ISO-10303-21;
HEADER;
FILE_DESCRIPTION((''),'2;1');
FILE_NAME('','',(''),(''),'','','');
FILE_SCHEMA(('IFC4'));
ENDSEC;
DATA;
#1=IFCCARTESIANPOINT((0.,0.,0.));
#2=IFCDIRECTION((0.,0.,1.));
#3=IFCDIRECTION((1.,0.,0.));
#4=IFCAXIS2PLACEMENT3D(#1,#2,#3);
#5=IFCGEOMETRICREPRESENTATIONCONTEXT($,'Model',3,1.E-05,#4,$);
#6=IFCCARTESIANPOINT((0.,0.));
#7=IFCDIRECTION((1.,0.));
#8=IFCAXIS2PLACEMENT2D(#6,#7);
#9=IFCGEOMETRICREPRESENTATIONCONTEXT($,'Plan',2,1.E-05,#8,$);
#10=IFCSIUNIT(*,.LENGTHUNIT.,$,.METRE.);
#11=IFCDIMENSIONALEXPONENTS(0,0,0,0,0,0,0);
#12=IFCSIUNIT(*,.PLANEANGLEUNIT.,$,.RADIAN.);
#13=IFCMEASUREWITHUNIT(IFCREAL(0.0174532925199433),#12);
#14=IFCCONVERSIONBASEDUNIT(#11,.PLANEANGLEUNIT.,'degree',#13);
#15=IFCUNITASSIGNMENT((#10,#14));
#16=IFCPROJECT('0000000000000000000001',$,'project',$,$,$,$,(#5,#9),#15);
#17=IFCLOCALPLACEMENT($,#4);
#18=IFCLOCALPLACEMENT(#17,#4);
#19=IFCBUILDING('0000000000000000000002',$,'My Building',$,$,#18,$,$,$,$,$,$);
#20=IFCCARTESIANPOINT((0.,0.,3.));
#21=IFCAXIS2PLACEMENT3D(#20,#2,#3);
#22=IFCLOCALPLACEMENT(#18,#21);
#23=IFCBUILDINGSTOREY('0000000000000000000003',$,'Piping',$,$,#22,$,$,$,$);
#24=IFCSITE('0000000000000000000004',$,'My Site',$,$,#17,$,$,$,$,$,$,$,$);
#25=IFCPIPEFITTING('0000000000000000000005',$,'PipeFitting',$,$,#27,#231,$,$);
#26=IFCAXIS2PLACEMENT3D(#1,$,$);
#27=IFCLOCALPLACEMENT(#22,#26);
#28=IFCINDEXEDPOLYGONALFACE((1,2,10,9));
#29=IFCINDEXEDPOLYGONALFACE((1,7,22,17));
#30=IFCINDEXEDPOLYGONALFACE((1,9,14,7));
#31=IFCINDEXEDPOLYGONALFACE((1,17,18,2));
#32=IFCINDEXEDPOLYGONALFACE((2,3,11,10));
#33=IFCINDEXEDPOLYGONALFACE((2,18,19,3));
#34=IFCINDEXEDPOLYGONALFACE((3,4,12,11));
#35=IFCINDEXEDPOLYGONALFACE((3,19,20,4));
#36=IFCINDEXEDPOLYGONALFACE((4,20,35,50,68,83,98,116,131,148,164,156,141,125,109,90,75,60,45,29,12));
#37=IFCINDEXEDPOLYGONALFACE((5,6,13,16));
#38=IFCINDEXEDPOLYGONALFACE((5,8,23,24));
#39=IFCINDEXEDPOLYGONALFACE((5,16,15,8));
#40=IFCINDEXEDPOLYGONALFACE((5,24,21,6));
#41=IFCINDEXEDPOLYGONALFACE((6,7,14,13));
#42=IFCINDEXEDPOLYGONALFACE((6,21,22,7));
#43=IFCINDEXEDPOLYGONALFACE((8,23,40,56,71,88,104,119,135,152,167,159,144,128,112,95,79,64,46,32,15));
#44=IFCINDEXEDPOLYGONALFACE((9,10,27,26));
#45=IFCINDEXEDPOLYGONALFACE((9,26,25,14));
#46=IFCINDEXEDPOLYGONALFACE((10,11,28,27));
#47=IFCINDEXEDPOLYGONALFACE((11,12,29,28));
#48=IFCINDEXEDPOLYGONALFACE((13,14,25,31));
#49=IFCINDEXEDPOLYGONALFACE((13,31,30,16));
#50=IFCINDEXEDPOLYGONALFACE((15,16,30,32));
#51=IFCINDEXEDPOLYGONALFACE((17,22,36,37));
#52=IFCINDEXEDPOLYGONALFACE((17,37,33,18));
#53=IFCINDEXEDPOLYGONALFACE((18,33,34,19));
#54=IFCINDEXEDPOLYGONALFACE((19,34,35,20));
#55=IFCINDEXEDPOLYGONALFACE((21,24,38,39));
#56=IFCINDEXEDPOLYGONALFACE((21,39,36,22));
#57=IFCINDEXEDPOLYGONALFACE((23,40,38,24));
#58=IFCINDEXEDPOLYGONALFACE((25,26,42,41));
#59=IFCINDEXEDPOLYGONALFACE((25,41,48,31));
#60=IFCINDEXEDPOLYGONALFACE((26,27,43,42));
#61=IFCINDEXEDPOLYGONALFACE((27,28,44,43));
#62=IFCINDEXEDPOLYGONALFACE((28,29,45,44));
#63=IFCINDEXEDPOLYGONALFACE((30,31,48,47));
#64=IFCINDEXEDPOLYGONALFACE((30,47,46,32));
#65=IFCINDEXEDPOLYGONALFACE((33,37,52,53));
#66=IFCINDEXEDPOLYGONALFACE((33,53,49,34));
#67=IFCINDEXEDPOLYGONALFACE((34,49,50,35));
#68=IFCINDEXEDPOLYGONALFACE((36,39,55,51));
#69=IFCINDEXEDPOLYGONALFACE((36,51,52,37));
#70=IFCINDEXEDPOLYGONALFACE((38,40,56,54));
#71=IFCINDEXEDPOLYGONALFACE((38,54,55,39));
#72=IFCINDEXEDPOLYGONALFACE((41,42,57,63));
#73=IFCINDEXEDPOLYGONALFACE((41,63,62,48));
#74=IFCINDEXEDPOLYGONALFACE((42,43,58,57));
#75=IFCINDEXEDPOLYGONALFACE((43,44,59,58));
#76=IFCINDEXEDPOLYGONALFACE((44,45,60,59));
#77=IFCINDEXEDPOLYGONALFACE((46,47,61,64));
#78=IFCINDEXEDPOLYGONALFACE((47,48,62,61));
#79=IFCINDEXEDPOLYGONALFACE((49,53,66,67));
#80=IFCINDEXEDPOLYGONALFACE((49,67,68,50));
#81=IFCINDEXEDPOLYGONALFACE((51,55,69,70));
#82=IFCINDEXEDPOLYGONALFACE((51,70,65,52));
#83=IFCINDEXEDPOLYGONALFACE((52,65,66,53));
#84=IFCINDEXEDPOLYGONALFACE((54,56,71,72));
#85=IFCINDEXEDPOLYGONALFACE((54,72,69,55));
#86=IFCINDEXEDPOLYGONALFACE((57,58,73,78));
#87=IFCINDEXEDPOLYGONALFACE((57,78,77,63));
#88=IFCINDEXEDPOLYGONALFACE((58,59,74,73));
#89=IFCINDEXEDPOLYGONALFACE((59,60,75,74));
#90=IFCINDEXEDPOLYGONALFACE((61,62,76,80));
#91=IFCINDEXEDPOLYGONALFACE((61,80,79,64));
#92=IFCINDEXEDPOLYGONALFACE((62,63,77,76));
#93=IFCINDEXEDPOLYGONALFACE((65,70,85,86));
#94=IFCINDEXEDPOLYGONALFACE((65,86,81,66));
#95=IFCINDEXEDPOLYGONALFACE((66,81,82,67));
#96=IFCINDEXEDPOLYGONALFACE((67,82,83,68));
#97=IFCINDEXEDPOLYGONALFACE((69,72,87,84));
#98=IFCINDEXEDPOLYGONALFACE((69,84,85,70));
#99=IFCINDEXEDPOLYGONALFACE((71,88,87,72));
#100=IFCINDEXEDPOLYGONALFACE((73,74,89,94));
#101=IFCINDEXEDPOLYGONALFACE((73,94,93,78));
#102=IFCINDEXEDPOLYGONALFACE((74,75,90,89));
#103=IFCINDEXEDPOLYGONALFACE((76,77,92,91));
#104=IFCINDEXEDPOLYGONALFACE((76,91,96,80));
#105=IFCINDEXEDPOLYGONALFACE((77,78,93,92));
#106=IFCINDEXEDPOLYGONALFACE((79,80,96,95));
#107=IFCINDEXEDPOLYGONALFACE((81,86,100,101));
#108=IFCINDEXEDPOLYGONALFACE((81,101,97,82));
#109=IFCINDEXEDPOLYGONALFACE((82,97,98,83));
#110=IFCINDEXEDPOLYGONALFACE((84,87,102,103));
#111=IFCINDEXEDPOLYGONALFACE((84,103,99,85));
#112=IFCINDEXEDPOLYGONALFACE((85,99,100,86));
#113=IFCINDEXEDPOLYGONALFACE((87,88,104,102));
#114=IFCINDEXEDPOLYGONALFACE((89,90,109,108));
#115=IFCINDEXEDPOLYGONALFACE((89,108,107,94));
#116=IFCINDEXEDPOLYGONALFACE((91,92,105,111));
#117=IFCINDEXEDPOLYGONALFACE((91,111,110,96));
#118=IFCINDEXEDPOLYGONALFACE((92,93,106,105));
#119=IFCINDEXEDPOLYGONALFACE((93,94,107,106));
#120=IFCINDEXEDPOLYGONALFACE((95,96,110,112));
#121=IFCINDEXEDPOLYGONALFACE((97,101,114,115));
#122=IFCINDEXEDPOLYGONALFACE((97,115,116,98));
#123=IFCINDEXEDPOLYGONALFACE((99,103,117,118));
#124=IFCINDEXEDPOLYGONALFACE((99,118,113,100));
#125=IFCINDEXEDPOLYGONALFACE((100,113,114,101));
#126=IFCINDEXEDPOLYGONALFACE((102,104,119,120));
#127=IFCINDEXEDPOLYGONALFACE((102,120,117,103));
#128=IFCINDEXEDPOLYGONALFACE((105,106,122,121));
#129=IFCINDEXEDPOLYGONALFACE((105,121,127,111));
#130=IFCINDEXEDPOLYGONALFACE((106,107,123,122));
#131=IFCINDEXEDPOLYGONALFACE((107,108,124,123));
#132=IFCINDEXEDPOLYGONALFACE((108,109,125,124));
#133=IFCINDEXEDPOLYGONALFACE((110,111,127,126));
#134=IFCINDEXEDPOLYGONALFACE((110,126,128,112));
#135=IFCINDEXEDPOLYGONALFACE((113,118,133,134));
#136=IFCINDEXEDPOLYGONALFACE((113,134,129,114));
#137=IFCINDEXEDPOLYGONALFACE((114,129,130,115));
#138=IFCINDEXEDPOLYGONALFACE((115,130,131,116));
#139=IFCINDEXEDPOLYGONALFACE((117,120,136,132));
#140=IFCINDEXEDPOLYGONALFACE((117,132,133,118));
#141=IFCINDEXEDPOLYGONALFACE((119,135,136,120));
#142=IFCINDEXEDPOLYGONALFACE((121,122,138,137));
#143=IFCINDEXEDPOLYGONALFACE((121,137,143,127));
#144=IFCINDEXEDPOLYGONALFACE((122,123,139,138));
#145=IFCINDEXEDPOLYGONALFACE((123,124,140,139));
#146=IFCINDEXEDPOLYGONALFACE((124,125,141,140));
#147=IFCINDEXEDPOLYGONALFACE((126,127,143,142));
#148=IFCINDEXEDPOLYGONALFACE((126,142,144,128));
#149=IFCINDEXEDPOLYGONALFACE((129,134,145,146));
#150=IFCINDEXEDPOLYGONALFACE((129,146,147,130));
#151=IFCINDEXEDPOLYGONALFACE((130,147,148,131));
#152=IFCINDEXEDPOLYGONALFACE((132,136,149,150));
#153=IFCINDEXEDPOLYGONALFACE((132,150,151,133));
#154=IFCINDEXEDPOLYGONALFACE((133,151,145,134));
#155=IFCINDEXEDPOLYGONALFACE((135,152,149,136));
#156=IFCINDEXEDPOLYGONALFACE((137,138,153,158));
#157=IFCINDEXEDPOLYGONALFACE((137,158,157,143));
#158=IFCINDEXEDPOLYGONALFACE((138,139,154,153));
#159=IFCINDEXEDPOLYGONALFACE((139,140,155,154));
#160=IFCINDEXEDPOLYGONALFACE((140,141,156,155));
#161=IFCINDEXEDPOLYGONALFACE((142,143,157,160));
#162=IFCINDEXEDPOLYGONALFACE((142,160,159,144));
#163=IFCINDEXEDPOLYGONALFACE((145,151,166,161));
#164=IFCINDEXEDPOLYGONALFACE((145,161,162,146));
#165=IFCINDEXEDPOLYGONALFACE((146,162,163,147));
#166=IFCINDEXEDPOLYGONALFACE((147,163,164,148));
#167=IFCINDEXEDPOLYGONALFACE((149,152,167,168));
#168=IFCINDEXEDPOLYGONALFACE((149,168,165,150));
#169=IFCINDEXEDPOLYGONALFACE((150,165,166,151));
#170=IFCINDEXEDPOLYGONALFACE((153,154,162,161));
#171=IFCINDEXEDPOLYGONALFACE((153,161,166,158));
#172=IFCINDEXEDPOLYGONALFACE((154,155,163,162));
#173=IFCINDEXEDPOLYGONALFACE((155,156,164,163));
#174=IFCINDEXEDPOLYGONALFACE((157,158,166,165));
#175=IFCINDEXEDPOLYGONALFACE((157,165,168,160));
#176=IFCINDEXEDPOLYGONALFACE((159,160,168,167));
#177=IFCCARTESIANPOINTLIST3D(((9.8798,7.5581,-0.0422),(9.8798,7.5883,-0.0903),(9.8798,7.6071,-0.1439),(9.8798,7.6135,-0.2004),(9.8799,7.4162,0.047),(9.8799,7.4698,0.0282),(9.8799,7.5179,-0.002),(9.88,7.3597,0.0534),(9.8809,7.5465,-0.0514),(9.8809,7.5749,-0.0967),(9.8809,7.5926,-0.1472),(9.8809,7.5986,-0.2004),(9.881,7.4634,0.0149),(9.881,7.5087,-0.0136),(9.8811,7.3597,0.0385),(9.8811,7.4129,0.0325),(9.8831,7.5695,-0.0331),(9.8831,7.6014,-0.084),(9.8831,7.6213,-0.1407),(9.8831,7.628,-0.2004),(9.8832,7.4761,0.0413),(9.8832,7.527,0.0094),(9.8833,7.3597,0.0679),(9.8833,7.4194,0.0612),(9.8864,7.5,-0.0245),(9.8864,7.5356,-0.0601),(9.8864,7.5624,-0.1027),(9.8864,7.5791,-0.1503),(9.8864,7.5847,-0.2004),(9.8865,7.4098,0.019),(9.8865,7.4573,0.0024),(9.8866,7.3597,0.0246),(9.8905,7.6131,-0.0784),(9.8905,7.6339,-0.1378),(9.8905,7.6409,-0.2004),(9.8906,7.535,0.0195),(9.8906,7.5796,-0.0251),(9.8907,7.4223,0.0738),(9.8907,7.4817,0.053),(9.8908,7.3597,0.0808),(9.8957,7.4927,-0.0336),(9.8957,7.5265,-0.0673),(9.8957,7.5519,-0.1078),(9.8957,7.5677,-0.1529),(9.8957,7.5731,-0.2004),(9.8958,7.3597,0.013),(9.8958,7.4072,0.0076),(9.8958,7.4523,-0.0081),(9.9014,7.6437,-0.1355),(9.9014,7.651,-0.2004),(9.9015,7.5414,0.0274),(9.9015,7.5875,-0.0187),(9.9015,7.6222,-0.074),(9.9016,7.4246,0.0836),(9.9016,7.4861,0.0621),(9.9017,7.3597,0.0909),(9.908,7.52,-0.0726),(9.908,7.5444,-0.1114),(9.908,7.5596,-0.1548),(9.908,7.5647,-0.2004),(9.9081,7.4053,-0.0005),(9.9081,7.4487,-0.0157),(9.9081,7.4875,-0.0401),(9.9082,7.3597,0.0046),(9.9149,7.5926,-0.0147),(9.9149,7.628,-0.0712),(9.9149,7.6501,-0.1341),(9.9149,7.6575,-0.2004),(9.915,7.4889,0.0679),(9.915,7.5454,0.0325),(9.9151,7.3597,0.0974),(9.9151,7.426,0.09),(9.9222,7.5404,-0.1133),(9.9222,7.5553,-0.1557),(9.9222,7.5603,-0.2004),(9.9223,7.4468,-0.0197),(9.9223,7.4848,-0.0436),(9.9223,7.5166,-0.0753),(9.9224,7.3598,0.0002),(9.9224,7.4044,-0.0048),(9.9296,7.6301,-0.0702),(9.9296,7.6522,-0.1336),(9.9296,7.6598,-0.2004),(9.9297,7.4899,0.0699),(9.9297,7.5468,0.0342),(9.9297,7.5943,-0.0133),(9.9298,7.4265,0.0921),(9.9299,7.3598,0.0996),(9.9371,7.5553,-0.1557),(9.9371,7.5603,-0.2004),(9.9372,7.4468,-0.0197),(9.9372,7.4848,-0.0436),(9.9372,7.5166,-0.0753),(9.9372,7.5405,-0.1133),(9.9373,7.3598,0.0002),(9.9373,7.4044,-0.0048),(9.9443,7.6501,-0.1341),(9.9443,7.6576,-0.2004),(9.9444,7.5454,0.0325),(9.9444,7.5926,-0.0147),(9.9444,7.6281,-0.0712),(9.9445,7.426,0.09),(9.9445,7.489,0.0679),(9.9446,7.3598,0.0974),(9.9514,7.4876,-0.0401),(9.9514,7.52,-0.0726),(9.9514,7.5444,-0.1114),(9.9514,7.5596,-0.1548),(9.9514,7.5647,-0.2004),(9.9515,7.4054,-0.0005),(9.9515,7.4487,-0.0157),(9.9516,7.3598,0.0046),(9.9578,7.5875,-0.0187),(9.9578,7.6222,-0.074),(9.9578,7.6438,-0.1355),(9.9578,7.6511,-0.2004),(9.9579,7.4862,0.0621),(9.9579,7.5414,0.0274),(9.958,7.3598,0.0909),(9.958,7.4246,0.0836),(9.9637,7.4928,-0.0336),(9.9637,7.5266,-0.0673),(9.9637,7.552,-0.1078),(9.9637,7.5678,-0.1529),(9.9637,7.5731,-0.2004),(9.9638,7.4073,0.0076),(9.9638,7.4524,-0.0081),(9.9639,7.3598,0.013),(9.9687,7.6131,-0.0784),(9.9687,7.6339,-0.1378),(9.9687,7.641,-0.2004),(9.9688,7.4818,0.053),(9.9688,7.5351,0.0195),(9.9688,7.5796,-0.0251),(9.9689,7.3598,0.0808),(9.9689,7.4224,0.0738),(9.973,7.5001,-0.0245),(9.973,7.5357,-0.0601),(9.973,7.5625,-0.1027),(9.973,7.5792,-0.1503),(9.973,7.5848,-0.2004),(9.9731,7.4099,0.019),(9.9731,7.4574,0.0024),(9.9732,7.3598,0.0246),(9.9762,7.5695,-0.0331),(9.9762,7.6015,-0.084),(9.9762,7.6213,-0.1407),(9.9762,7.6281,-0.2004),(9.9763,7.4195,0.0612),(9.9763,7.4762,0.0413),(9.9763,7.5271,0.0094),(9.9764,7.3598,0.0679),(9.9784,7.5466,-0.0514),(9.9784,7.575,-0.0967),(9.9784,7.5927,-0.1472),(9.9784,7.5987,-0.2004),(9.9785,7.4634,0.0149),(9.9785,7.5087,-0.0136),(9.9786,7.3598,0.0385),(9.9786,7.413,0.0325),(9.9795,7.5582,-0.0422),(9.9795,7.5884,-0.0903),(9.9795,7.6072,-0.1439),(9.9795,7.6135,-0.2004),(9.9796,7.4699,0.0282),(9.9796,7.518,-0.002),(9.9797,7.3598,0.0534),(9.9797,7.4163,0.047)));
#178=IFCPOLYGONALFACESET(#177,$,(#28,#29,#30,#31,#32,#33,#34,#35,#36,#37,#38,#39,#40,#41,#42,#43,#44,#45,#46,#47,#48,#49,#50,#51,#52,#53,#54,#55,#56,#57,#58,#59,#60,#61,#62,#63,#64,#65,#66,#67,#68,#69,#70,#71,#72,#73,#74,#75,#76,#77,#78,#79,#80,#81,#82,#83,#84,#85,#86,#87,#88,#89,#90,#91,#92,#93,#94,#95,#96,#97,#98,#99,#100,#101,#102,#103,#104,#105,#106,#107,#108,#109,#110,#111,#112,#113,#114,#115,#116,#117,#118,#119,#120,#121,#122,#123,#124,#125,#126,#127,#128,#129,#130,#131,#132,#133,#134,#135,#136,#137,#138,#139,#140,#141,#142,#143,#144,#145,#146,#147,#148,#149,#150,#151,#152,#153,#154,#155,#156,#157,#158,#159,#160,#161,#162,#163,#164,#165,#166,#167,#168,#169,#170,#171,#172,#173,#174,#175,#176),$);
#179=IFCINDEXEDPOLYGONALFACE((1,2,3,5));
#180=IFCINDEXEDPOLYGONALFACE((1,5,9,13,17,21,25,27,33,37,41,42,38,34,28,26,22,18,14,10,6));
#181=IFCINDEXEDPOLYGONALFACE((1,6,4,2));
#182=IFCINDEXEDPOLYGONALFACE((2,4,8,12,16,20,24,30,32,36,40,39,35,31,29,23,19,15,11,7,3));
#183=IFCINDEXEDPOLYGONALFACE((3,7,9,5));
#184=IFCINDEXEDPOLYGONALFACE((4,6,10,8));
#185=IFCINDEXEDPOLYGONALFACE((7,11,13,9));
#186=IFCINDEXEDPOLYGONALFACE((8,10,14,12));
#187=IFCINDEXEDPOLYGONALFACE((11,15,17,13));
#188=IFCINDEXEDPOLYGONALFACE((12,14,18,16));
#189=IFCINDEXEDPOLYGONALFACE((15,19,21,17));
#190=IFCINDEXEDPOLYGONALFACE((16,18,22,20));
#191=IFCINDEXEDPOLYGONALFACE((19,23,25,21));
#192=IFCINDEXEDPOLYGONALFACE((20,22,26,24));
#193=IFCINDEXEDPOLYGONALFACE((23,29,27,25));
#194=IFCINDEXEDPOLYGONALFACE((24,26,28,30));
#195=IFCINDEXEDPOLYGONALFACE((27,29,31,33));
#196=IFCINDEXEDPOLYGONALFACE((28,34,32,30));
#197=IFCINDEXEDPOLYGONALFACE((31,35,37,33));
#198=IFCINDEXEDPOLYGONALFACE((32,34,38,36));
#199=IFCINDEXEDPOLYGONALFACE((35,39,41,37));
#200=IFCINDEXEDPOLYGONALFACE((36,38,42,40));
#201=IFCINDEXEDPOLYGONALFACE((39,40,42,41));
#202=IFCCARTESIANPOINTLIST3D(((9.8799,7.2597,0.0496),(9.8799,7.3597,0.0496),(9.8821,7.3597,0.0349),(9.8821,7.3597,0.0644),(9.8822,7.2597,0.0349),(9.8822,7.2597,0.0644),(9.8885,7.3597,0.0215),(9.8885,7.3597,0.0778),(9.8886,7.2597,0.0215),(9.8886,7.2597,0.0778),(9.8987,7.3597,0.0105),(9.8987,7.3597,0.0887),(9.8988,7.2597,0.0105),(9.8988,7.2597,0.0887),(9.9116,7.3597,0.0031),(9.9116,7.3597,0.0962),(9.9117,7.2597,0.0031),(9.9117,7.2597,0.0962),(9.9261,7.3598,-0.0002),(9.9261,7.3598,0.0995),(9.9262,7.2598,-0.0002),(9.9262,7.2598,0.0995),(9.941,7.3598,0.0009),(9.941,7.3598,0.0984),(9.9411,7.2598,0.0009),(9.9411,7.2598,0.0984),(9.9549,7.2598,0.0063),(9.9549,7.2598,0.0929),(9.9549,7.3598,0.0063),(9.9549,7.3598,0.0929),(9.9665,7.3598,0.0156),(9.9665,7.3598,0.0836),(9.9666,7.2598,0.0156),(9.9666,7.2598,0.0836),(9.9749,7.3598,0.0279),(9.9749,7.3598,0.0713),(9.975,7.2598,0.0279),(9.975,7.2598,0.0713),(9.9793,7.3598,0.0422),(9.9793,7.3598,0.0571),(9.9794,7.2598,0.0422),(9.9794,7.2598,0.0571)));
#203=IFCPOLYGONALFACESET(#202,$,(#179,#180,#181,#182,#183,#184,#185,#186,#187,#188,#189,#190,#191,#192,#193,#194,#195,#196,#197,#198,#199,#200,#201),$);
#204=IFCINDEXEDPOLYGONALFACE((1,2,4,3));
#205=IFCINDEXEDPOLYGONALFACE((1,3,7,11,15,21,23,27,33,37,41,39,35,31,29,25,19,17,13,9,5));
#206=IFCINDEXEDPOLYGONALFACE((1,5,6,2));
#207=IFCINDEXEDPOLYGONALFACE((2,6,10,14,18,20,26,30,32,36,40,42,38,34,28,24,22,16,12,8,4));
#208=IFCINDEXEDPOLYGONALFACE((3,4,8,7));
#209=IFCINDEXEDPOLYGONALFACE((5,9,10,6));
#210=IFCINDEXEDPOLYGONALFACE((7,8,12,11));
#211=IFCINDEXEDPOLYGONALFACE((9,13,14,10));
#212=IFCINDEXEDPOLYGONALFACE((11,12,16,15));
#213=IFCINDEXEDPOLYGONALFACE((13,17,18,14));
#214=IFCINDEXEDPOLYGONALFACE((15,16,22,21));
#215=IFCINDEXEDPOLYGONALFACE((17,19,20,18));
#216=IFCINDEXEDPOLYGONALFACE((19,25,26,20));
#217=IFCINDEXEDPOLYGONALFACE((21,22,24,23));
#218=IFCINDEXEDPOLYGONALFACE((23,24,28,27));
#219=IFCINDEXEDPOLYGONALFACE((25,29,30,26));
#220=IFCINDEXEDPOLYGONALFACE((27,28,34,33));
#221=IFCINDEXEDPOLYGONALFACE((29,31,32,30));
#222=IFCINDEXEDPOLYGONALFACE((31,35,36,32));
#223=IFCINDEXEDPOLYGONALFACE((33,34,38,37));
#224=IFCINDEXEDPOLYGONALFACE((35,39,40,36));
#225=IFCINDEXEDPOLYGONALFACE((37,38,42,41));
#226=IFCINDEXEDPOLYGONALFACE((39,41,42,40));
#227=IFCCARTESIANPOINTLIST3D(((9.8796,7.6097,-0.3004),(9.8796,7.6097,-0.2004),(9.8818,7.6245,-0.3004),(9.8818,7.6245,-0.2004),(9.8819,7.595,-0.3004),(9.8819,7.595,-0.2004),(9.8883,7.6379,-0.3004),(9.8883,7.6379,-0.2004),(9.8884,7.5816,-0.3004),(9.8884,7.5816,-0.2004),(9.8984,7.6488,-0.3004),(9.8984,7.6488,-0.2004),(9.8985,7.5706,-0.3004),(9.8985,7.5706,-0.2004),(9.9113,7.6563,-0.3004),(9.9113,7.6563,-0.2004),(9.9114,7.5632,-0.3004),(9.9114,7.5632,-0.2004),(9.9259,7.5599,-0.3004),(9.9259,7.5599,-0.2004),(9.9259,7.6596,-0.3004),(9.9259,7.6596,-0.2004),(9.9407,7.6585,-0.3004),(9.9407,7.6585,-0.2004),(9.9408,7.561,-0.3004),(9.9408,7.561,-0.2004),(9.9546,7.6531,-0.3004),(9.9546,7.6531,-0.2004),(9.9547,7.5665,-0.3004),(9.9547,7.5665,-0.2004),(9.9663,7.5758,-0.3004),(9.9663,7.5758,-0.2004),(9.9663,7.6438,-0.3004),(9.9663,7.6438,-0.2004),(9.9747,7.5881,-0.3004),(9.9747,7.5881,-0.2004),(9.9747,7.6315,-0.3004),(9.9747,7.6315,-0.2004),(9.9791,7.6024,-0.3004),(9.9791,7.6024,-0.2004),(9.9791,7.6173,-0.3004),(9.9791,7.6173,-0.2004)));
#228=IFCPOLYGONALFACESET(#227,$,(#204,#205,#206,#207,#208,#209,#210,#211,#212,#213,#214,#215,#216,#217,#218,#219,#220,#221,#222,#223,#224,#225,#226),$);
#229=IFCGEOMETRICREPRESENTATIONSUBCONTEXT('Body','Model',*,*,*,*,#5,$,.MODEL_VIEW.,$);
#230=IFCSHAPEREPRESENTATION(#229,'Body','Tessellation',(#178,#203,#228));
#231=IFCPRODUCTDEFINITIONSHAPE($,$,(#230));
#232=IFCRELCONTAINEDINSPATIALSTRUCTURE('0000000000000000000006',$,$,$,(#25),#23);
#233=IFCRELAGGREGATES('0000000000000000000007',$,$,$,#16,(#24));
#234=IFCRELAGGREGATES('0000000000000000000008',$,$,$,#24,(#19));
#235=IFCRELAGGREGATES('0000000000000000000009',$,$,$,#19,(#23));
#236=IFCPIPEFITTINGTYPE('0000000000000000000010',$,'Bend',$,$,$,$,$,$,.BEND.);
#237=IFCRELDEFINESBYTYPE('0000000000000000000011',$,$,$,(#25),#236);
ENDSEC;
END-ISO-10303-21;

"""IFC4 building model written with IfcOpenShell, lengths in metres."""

from ifc_helpers import new_model, entity, si_unit, converted_unit, frame, origin_with_axes, origin_2d_with_axis, place, context, subcontext, project, spatial, circle, extrude, source, transform, mapped, type_object, type_shapes, element, save


model = new_model("IFC4")

# Units and contexts
model_context = context("Model", 3, precision=1e-05, world=origin_with_axes())
plan_context = context("Plan", 2, precision=1e-05, world=origin_2d_with_axis())
body_context = subcontext(model_context, "Body", "Model", "MODEL_VIEW")
ifc_project = project(units=[si_unit("LENGTHUNIT", "METRE"), converted_unit("PLANEANGLEUNIT", "degree", entity("IfcReal", 0.0174532925199433), si_unit("PLANEANGLEUNIT", "RADIAN"), dimensions=[0, 0, 0, 0, 0, 0, 0])], contexts=[model_context, plan_context])

# Site, building, storey
site_placement = place(None, origin_with_axes())
site = spatial("IfcSite", under=ifc_project, at=site_placement, Name="My Site")
building_placement = place(site_placement, origin_with_axes())
building = spatial("IfcBuilding", under=site, at=building_placement, Name="My Building")
storey_placement = place(building_placement, frame((0.0, 0.0, 3.0), z_axis=(0.0, 0.0, 1.0), x_axis=(1.0, 0.0, 0.0)))
storey = spatial("IfcBuildingStorey", under=building, at=storey_placement, Name="Piping")

# Pipe fitting
pipe_fitting_type_1 = type_object("IfcPipeFittingType", Name="Bend", PredefinedType="BEND")
shared_shape = source(origin_with_axes(), body_context, "Body", "SolidModel", [
    entity("IfcSweptDiskSolid", entity("IfcIndexedPolyCurve", entity("IfcCartesianPointList3D", [[0.0, 0.0, 0.1], [0.0, -0.0732, 0.2768], [0.0, -0.25, 0.35]]), [entity("IfcArcIndex", [1, 2, 3])]), 0.05),
    extrude(circle(Radius=0.05), origin_with_axes(), (0.0, 0.0, 1.0), 0.1),
    extrude(circle(Radius=0.05), frame((0.0, -0.25, 0.35), z_axis=(0.0, -1.0, -0.000001), x_axis=(1.0, 0.0, 0.0)), (0.0, 0.0, 1.0), 0.1),
])
type_shapes(pipe_fitting_type_1, [shared_shape])
for number, where, z_axis, x_axis, name in (
    (1, (9.9299, 7.2598, 0.0496), (-0.000872, 1.0, 0.000001), (-1.0, -0.000872, 0.0), "PipeFitting"),
):
    element("IfcPipeFitting", number, at=place(storey_placement, frame(where, z_axis=z_axis, x_axis=x_axis)), inside=storey, type_object=pipe_fitting_type_1, Name=name, context=body_context, shape_type="MappedRepresentation", body=[
        mapped(shared_shape, transform((0.0, 0.0, 0.0), x_axis=(1.0, 0.0, 0.0), y_axis=(0.0, 1.0, 0.0), z_axis=(0.0, 0.0, 1.0), scale=1.0)),
    ])

save(model, "model.ifc")
